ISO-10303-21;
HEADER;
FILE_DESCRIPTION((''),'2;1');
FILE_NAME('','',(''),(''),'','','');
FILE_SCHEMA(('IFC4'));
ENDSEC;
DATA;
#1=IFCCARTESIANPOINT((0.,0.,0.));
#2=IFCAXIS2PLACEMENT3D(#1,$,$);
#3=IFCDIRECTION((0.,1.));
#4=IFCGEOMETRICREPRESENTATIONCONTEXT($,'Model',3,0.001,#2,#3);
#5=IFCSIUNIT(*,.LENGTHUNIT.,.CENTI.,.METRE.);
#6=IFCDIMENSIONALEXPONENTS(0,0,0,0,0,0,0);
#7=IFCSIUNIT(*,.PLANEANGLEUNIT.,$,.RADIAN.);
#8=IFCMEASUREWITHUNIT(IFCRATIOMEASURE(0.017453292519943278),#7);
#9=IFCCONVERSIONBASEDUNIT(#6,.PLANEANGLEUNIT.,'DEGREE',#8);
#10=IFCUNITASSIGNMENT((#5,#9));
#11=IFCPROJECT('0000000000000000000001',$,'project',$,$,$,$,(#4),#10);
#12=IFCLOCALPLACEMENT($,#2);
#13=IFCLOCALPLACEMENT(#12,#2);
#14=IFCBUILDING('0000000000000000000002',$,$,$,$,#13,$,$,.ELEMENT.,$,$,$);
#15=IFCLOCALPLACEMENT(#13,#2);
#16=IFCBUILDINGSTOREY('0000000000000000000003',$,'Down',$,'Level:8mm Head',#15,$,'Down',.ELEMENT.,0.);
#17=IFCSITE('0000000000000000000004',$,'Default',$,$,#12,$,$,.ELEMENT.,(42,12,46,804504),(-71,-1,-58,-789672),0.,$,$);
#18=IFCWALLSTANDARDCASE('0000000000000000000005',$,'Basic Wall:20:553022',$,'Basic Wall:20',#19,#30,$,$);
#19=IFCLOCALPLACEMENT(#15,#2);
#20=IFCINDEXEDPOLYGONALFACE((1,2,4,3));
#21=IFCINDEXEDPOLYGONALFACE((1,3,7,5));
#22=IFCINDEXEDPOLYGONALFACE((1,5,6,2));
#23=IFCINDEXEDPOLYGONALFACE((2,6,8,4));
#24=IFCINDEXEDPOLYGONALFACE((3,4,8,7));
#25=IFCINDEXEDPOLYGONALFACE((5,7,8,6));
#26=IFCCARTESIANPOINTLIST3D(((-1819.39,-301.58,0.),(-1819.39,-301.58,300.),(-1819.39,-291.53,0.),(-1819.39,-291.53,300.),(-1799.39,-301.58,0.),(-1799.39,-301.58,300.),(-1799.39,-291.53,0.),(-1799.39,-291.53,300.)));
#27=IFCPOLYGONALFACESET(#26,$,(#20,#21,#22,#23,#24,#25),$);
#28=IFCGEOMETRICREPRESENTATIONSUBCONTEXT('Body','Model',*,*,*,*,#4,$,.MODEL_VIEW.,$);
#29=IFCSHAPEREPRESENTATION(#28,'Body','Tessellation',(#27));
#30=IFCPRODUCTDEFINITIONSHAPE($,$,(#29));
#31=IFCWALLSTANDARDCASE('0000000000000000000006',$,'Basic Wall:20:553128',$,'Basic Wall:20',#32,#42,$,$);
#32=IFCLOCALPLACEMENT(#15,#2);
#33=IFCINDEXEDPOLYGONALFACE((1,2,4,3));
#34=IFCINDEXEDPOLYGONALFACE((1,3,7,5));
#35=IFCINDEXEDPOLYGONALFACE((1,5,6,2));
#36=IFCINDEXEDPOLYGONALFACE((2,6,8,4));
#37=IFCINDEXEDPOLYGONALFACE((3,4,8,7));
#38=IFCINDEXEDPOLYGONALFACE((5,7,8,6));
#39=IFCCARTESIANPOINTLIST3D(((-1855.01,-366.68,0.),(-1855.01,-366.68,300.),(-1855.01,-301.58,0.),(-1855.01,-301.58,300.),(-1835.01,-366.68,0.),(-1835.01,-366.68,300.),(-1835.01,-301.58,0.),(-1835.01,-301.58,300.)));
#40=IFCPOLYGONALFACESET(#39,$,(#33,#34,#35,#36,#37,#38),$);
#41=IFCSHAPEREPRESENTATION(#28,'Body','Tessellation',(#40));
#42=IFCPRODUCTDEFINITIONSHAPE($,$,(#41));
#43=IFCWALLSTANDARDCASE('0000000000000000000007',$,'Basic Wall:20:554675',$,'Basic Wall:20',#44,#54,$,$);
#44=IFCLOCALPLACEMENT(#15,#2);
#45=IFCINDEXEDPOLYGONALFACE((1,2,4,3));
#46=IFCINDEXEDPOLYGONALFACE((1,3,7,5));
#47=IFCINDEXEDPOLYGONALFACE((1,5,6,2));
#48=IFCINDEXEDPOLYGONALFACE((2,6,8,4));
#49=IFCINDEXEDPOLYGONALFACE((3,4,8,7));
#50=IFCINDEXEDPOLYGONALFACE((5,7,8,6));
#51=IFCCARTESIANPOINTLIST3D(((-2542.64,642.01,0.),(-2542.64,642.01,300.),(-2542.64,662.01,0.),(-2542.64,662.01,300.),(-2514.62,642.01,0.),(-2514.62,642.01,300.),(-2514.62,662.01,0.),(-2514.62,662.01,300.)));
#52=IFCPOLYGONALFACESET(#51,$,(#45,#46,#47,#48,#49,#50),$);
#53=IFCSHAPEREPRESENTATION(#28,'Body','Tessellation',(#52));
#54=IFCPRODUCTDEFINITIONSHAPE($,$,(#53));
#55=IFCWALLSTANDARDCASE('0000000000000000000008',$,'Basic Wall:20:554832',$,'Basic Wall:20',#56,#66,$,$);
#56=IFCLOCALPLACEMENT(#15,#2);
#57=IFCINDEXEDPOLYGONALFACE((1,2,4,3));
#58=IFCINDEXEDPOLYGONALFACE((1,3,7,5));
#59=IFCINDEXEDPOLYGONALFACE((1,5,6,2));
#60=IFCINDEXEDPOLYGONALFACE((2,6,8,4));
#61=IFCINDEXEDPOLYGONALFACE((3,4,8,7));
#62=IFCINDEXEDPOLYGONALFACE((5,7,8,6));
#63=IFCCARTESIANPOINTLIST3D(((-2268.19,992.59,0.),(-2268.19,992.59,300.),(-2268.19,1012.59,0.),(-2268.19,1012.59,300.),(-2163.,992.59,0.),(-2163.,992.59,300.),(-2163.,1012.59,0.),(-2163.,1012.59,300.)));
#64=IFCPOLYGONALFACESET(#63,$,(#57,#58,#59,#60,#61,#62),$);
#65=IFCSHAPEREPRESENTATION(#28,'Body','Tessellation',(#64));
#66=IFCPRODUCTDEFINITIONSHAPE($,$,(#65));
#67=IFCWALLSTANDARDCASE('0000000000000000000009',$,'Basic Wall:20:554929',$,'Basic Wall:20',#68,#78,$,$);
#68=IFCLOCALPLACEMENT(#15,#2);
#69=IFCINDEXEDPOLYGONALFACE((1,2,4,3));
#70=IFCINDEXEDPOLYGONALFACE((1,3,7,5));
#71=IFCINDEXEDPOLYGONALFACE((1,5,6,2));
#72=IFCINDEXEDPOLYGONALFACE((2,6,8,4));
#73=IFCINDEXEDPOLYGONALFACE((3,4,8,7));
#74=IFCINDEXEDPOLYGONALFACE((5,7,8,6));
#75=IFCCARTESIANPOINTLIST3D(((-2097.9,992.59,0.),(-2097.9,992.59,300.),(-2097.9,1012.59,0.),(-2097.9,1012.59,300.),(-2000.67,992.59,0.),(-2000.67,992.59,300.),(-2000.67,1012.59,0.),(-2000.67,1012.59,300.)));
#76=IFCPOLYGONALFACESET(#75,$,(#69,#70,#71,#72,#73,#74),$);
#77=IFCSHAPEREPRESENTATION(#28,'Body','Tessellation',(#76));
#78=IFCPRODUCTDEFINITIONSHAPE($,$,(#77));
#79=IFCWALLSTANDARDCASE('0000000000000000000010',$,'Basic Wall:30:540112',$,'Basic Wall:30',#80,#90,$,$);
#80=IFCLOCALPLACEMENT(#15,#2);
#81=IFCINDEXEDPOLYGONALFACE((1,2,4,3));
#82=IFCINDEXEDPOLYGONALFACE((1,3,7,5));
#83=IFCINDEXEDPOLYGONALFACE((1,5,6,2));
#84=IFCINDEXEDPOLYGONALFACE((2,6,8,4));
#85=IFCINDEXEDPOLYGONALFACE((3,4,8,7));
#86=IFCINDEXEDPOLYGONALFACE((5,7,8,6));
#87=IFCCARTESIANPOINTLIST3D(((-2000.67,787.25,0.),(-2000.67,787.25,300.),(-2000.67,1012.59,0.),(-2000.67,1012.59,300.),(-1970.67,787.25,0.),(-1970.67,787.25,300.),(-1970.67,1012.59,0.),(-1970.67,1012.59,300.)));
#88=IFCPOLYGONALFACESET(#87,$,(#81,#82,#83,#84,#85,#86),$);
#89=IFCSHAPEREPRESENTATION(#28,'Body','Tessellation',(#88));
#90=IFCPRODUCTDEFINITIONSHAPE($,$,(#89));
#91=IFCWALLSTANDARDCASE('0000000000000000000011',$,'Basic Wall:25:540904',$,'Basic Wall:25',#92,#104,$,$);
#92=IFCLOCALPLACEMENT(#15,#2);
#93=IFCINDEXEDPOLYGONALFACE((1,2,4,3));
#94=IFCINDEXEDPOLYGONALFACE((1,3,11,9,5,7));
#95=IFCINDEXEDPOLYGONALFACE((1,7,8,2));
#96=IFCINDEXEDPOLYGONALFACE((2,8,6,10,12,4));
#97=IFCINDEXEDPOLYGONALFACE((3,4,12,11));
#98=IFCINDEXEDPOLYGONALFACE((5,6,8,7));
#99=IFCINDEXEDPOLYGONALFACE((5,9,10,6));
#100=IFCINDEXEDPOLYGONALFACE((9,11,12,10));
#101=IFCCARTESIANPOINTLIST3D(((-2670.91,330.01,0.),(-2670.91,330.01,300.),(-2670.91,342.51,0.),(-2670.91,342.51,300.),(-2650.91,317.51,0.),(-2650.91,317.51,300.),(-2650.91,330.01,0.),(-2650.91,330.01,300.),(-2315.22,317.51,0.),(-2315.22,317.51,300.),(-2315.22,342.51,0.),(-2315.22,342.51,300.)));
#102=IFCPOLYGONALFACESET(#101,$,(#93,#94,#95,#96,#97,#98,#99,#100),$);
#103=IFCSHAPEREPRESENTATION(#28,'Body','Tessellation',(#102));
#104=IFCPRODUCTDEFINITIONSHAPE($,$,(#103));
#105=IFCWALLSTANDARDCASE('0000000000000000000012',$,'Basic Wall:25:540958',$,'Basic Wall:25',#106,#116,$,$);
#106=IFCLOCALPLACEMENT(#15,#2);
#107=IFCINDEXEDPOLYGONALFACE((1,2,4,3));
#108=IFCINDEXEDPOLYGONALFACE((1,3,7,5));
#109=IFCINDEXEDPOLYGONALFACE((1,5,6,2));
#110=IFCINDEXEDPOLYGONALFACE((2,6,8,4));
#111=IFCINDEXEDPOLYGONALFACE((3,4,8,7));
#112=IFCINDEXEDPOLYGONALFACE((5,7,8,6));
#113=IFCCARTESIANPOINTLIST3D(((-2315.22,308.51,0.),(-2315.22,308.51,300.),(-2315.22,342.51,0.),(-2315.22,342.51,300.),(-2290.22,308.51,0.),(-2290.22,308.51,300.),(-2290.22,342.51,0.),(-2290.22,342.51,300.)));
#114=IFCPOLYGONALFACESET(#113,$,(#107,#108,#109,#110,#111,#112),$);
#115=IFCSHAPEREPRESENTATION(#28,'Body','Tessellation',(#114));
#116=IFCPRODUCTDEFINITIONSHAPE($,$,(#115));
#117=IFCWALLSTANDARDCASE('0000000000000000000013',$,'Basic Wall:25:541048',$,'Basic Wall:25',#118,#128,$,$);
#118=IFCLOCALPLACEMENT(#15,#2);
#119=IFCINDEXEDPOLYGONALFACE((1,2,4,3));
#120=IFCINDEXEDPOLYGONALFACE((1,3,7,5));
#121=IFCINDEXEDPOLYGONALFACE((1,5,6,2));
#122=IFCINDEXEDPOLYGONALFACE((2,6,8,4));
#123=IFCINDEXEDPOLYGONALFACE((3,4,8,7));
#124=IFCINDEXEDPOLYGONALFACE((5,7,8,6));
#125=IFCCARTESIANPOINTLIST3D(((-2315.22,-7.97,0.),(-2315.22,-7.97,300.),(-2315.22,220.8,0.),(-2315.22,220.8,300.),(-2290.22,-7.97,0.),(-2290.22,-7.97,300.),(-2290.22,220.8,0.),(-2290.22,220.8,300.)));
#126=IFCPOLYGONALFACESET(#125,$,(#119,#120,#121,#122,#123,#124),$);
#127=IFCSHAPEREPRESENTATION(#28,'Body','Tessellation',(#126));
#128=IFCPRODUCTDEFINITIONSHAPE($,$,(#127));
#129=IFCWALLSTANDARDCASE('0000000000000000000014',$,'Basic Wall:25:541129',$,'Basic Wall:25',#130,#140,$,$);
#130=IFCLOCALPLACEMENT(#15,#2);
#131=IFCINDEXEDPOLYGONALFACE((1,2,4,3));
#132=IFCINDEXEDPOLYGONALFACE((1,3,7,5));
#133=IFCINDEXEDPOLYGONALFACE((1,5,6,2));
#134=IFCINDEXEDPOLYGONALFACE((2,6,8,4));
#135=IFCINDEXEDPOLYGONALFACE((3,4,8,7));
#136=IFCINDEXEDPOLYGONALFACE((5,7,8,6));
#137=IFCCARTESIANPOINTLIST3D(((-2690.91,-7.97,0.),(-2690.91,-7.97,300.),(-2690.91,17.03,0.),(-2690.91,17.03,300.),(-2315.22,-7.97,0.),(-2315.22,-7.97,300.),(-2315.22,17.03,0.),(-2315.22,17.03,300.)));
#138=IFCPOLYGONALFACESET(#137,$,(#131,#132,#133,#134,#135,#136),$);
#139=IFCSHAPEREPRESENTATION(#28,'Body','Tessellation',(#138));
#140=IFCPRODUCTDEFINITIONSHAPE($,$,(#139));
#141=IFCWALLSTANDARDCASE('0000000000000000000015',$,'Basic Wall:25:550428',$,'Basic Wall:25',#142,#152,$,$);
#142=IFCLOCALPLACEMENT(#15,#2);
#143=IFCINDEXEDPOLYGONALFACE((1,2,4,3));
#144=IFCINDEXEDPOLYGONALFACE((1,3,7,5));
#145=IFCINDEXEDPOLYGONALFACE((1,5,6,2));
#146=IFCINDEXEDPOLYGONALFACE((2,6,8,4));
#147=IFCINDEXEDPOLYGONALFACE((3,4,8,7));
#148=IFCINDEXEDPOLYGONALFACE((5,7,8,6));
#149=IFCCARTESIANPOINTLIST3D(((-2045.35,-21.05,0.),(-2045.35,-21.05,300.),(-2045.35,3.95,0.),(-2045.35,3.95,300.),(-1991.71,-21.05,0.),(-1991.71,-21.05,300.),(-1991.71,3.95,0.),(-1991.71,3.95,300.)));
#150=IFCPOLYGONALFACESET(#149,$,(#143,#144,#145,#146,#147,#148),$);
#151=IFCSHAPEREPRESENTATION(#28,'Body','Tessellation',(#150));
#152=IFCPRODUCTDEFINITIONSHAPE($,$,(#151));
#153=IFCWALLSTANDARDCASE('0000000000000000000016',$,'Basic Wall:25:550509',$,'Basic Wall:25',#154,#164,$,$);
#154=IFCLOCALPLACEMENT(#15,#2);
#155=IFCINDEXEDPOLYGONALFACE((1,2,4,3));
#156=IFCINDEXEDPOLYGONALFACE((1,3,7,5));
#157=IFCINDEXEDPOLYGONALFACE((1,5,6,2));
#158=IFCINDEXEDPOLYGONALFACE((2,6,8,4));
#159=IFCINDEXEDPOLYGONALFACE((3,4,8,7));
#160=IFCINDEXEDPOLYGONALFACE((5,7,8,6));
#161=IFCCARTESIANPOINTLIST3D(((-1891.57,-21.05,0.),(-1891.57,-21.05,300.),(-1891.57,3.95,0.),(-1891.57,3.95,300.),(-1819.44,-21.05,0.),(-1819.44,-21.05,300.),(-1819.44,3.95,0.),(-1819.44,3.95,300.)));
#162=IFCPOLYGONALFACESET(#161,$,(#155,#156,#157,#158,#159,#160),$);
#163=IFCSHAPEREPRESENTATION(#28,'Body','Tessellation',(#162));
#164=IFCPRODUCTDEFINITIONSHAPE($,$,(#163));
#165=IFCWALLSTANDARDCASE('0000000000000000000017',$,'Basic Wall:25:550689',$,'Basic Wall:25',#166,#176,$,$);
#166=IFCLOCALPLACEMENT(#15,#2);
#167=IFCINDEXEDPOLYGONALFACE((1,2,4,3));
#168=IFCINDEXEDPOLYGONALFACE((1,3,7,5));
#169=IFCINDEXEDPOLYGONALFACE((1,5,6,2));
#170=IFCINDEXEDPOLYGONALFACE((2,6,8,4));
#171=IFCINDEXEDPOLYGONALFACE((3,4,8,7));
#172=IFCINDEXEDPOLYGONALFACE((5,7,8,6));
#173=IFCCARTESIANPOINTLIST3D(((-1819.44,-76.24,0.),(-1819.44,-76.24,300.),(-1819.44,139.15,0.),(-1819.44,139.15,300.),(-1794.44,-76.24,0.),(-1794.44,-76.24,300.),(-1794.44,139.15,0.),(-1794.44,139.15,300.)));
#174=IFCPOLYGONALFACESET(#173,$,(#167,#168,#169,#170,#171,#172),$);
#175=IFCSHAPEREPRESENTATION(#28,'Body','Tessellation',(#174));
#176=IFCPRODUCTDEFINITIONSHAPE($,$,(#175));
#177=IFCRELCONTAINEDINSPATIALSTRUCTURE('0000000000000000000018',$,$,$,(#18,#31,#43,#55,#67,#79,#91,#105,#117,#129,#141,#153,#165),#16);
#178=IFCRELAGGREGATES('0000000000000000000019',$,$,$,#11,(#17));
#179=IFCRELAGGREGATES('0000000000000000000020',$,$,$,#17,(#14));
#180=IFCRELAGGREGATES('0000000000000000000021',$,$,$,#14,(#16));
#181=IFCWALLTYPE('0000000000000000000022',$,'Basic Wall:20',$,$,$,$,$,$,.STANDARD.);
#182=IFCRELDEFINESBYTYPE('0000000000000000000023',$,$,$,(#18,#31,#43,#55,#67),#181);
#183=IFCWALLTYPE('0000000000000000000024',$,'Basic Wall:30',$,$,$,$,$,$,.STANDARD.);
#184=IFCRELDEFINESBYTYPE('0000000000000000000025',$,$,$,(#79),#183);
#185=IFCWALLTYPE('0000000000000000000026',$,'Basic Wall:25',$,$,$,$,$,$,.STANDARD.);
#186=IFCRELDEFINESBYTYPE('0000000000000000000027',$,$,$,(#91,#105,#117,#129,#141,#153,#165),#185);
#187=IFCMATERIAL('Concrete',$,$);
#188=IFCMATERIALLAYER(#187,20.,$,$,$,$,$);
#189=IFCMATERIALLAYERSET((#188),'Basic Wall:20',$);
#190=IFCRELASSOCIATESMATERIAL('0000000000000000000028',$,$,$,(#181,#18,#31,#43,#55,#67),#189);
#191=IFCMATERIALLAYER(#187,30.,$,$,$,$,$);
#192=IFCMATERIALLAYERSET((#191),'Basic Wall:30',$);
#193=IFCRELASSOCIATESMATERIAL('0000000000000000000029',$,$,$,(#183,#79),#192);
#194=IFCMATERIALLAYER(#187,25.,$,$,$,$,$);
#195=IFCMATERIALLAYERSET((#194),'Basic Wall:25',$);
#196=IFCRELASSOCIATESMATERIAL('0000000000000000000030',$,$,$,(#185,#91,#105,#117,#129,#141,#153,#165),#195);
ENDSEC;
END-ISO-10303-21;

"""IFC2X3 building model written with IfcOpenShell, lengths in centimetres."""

from ifc_helpers import new_model, entity, si_unit, converted_unit, direction, frame, frame_2d, origin, place, context, subcontext, project, spatial, polyline, rectangle, outline, extrude, material, layer, layer_set, layer_usage, type_object, element, save


model = new_model("IFC2X3")

# Units and contexts
model_context = context("Model", 3, precision=0.001, world=origin(), true_north=direction((0.0, 1.0)))
body_context = subcontext(model_context, "Body", "Model", "MODEL_VIEW")
ifc_project = project(units=[si_unit("LENGTHUNIT", "METRE", prefix="CENTI"), converted_unit("PLANEANGLEUNIT", "DEGREE", entity("IfcRatioMeasure", 0.017453292519943278), si_unit("PLANEANGLEUNIT", "RADIAN"), dimensions=[0, 0, 0, 0, 0, 0, 0])], contexts=[model_context])

# Site, building, storey
site_placement = place(None, origin())
site = spatial("IfcSite", under=ifc_project, at=site_placement, Name="Default", CompositionType="ELEMENT", RefLatitude=(42, 12, 46, 804504), RefLongitude=(-71, -1, -58, -789672), RefElevation=0.0)
building_placement = place(site_placement, origin())
building = spatial("IfcBuilding", under=site, at=building_placement, CompositionType="ELEMENT")
storey_placement = place(building_placement, origin())
storey = spatial("IfcBuildingStorey", under=building, at=storey_placement, Name="Down", ObjectType="Level:8mm Head", LongName="Down", CompositionType="ELEMENT", Elevation=0.0)

# Walls
ifc_material = material(Name="Concrete")
ifc_layer_1 = layer(ifc_material, 20.0)
ifc_layer_set_1 = layer_set([ifc_layer_1], Name="Basic Wall:20")
wall_type_1 = type_object("IfcWallType", Name="Basic Wall:20", PredefinedType="STANDARD", material=ifc_layer_set_1)
ifc_layer_usage_1 = layer_usage(ifc_layer_set_1, "AXIS2", "NEGATIVE", 10.0)
wall_1_placement = place(storey_placement, frame((-1809.39, -291.53, 0.0), z_axis=(0.0, 0.0, 1.0), x_axis=(0.0, -1.0, 0.0)))
element("IfcWallStandardCase", 1, at=wall_1_placement, inside=storey, type_object=wall_type_1, material=ifc_layer_usage_1, Name="Basic Wall:20:553022", ObjectType="Basic Wall:20", context=body_context, shape_type="SweptSolid", body=[
    extrude(rectangle(XDim=10.05, YDim=20.0, at=frame_2d((5.02, 0.0), x_axis=(-1.0, 0.0))), origin(), (0.0, 0.0, 1.0), 300.0),
])
ifc_layer_usage_2 = layer_usage(ifc_layer_set_1, "AXIS2", "POSITIVE", -10.0)
wall_2_placement = place(storey_placement, frame((-1845.01, -301.58, 0.0), z_axis=(0.0, 0.0, 1.0), x_axis=(0.0, -1.0, 0.0)))
element("IfcWallStandardCase", 2, at=wall_2_placement, inside=storey, type_object=wall_type_1, material=ifc_layer_usage_2, Name="Basic Wall:20:553128", ObjectType="Basic Wall:20", context=body_context, shape_type="SweptSolid", body=[
    extrude(rectangle(XDim=65.1, YDim=20.0, at=frame_2d((32.55, 0.0), x_axis=(-1.0, 0.0))), origin(), (0.0, 0.0, 1.0), 300.0),
])
ifc_layer_usage_3 = layer_usage(ifc_layer_set_1, "AXIS2", "NEGATIVE", 10.0)
wall_3_placement = place(storey_placement, frame((-2514.62, 652.01, 0.0), z_axis=(0.0, 0.0, 1.0), x_axis=(-1.0, 0.0, 0.0)))
element("IfcWallStandardCase", 3, at=wall_3_placement, inside=storey, type_object=wall_type_1, material=ifc_layer_usage_3, Name="Basic Wall:20:554675", ObjectType="Basic Wall:20", context=body_context, shape_type="SweptSolid", body=[
    extrude(rectangle(XDim=28.02, YDim=20.0, at=frame_2d((14.01, 0.0), x_axis=(-1.0, 0.0))), origin(), (0.0, 0.0, 1.0), 300.0),
])
ifc_layer_usage_4 = layer_usage(ifc_layer_set_1, "AXIS2", "POSITIVE", -10.0)
wall_4_placement = place(storey_placement, frame((-2268.19, 1002.59, 0.0)))
element("IfcWallStandardCase", 4, at=wall_4_placement, inside=storey, type_object=wall_type_1, material=ifc_layer_usage_4, Name="Basic Wall:20:554832", ObjectType="Basic Wall:20", context=body_context, shape_type="SweptSolid", body=[
    extrude(rectangle(XDim=105.2, YDim=20.0, at=frame_2d((52.6, 0.0), x_axis=(-1.0, 0.0))), origin(), (0.0, 0.0, 1.0), 300.0),
])
ifc_layer_usage_5 = layer_usage(ifc_layer_set_1, "AXIS2", "POSITIVE", -10.0)
wall_5_placement = place(storey_placement, frame((-2097.9, 1002.59, 0.0)))
element("IfcWallStandardCase", 5, at=wall_5_placement, inside=storey, type_object=wall_type_1, material=ifc_layer_usage_5, Name="Basic Wall:20:554929", ObjectType="Basic Wall:20", context=body_context, shape_type="SweptSolid", body=[
    extrude(rectangle(XDim=97.23, YDim=20.0, at=frame_2d((48.61, 0.0), x_axis=(-1.0, 0.0))), origin(), (0.0, 0.0, 1.0), 300.0),
])
ifc_layer_2 = layer(ifc_material, 30.0)
ifc_layer_set_2 = layer_set([ifc_layer_2], Name="Basic Wall:30")
ifc_layer_usage_6 = layer_usage(ifc_layer_set_2, "AXIS2", "NEGATIVE", 15.0)
wall_type_2 = type_object("IfcWallType", Name="Basic Wall:30", PredefinedType="STANDARD", material=ifc_layer_set_2)
wall_6_placement = place(storey_placement, frame((-1985.67, 787.25, 0.0), z_axis=(0.0, 0.0, 1.0), x_axis=(0.0, 1.0, 0.0)))
element("IfcWallStandardCase", 6, at=wall_6_placement, inside=storey, type_object=wall_type_2, material=ifc_layer_usage_6, Name="Basic Wall:30:540112", ObjectType="Basic Wall:30", context=body_context, shape_type="SweptSolid", body=[
    extrude(rectangle(XDim=225.34, YDim=30.0, at=frame_2d((112.67, 0.0), x_axis=(-1.0, 0.0))), origin(), (0.0, 0.0, 1.0), 300.0),
])
ifc_layer_3 = layer(ifc_material, 25.0)
ifc_layer_set_3 = layer_set([ifc_layer_3], Name="Basic Wall:25")
ifc_layer_usage_7 = layer_usage(ifc_layer_set_3, "AXIS2", "NEGATIVE", 12.5)
wall_type_3 = type_object("IfcWallType", Name="Basic Wall:25", PredefinedType="STANDARD", material=ifc_layer_set_3)
wall_7_placement = place(storey_placement, frame((-2670.91, 330.01, 0.0)))
element("IfcWallStandardCase", 7, at=wall_7_placement, inside=storey, type_object=wall_type_3, material=ifc_layer_usage_7, Name="Basic Wall:25:540904", ObjectType="Basic Wall:25", context=body_context, shape_type="SweptSolid", body=[
    extrude(outline(polyline([(355.68, -12.5), (355.68, 12.5), (0.0, 12.5), (0.0, 0.0), (20.0, 0.0), (20.0, -12.5), (355.68, -12.5)])), origin(), (0.0, 0.0, 1.0), 300.0),
])
ifc_layer_usage_8 = layer_usage(ifc_layer_set_3, "AXIS2", "NEGATIVE", 12.5)
wall_8_placement = place(storey_placement, frame((-2302.72, 342.51, 0.0), z_axis=(0.0, 0.0, 1.0), x_axis=(0.0, -1.0, 0.0)))
element("IfcWallStandardCase", 8, at=wall_8_placement, inside=storey, type_object=wall_type_3, material=ifc_layer_usage_8, Name="Basic Wall:25:540958", ObjectType="Basic Wall:25", context=body_context, shape_type="SweptSolid", body=[
    extrude(rectangle(XDim=34.0, YDim=25.0, at=frame_2d((17.0, 0.0), x_axis=(-1.0, 0.0))), origin(), (0.0, 0.0, 1.0), 300.0),
])
ifc_layer_usage_9 = layer_usage(ifc_layer_set_3, "AXIS2", "NEGATIVE", 12.5)
wall_9_placement = place(storey_placement, frame((-2302.72, 220.8, 0.0), z_axis=(0.0, 0.0, 1.0), x_axis=(0.0, -1.0, 0.0)))
element("IfcWallStandardCase", 9, at=wall_9_placement, inside=storey, type_object=wall_type_3, material=ifc_layer_usage_9, Name="Basic Wall:25:541048", ObjectType="Basic Wall:25", context=body_context, shape_type="SweptSolid", body=[
    extrude(rectangle(XDim=228.78, YDim=25.0, at=frame_2d((114.39, 0.0), x_axis=(-1.0, 0.0))), origin(), (0.0, 0.0, 1.0), 300.0),
])
ifc_layer_usage_10 = layer_usage(ifc_layer_set_3, "AXIS2", "NEGATIVE", 12.5)
wall_10_placement = place(storey_placement, frame((-2315.22, 4.53, 0.0), z_axis=(0.0, 0.0, 1.0), x_axis=(-1.0, 0.0, 0.0)))
element("IfcWallStandardCase", 10, at=wall_10_placement, inside=storey, type_object=wall_type_3, material=ifc_layer_usage_10, Name="Basic Wall:25:541129", ObjectType="Basic Wall:25", context=body_context, shape_type="SweptSolid", body=[
    extrude(rectangle(XDim=375.68, YDim=25.0, at=frame_2d((187.84, 0.0), x_axis=(-1.0, 0.0))), origin(), (0.0, 0.0, 1.0), 300.0),
])
ifc_layer_usage_11 = layer_usage(ifc_layer_set_3, "AXIS2", "NEGATIVE", 12.5)
wall_11_placement = place(storey_placement, frame((-2045.35, -8.55, 0.0)))
element("IfcWallStandardCase", 11, at=wall_11_placement, inside=storey, type_object=wall_type_3, material=ifc_layer_usage_11, Name="Basic Wall:25:550428", ObjectType="Basic Wall:25", context=body_context, shape_type="SweptSolid", body=[
    extrude(rectangle(XDim=53.64, YDim=25.0, at=frame_2d((26.82, 0.0), x_axis=(-1.0, 0.0))), origin(), (0.0, 0.0, 1.0), 300.0),
])
ifc_layer_usage_12 = layer_usage(ifc_layer_set_3, "AXIS2", "NEGATIVE", 12.5)
wall_12_placement = place(storey_placement, frame((-1891.57, -8.55, 0.0)))
element("IfcWallStandardCase", 12, at=wall_12_placement, inside=storey, type_object=wall_type_3, material=ifc_layer_usage_12, Name="Basic Wall:25:550509", ObjectType="Basic Wall:25", context=body_context, shape_type="SweptSolid", body=[
    extrude(rectangle(XDim=72.13, YDim=25.0, at=frame_2d((36.06, 0.0), x_axis=(-1.0, 0.0))), origin(), (0.0, 0.0, 1.0), 300.0),
])
ifc_layer_usage_13 = layer_usage(ifc_layer_set_3, "AXIS2", "POSITIVE", -12.5)
wall_13_placement = place(storey_placement, frame((-1806.94, 139.15, 0.0), z_axis=(0.0, 0.0, 1.0), x_axis=(0.0, -1.0, 0.0)))
element("IfcWallStandardCase", 13, at=wall_13_placement, inside=storey, type_object=wall_type_3, material=ifc_layer_usage_13, Name="Basic Wall:25:550689", ObjectType="Basic Wall:25", context=body_context, shape_type="SweptSolid", body=[
    extrude(rectangle(XDim=215.39, YDim=25.0, at=frame_2d((107.7, 0.0), x_axis=(-1.0, 0.0))), origin(), (0.0, 0.0, 1.0), 300.0),
])

save(model, "model.ifc")
